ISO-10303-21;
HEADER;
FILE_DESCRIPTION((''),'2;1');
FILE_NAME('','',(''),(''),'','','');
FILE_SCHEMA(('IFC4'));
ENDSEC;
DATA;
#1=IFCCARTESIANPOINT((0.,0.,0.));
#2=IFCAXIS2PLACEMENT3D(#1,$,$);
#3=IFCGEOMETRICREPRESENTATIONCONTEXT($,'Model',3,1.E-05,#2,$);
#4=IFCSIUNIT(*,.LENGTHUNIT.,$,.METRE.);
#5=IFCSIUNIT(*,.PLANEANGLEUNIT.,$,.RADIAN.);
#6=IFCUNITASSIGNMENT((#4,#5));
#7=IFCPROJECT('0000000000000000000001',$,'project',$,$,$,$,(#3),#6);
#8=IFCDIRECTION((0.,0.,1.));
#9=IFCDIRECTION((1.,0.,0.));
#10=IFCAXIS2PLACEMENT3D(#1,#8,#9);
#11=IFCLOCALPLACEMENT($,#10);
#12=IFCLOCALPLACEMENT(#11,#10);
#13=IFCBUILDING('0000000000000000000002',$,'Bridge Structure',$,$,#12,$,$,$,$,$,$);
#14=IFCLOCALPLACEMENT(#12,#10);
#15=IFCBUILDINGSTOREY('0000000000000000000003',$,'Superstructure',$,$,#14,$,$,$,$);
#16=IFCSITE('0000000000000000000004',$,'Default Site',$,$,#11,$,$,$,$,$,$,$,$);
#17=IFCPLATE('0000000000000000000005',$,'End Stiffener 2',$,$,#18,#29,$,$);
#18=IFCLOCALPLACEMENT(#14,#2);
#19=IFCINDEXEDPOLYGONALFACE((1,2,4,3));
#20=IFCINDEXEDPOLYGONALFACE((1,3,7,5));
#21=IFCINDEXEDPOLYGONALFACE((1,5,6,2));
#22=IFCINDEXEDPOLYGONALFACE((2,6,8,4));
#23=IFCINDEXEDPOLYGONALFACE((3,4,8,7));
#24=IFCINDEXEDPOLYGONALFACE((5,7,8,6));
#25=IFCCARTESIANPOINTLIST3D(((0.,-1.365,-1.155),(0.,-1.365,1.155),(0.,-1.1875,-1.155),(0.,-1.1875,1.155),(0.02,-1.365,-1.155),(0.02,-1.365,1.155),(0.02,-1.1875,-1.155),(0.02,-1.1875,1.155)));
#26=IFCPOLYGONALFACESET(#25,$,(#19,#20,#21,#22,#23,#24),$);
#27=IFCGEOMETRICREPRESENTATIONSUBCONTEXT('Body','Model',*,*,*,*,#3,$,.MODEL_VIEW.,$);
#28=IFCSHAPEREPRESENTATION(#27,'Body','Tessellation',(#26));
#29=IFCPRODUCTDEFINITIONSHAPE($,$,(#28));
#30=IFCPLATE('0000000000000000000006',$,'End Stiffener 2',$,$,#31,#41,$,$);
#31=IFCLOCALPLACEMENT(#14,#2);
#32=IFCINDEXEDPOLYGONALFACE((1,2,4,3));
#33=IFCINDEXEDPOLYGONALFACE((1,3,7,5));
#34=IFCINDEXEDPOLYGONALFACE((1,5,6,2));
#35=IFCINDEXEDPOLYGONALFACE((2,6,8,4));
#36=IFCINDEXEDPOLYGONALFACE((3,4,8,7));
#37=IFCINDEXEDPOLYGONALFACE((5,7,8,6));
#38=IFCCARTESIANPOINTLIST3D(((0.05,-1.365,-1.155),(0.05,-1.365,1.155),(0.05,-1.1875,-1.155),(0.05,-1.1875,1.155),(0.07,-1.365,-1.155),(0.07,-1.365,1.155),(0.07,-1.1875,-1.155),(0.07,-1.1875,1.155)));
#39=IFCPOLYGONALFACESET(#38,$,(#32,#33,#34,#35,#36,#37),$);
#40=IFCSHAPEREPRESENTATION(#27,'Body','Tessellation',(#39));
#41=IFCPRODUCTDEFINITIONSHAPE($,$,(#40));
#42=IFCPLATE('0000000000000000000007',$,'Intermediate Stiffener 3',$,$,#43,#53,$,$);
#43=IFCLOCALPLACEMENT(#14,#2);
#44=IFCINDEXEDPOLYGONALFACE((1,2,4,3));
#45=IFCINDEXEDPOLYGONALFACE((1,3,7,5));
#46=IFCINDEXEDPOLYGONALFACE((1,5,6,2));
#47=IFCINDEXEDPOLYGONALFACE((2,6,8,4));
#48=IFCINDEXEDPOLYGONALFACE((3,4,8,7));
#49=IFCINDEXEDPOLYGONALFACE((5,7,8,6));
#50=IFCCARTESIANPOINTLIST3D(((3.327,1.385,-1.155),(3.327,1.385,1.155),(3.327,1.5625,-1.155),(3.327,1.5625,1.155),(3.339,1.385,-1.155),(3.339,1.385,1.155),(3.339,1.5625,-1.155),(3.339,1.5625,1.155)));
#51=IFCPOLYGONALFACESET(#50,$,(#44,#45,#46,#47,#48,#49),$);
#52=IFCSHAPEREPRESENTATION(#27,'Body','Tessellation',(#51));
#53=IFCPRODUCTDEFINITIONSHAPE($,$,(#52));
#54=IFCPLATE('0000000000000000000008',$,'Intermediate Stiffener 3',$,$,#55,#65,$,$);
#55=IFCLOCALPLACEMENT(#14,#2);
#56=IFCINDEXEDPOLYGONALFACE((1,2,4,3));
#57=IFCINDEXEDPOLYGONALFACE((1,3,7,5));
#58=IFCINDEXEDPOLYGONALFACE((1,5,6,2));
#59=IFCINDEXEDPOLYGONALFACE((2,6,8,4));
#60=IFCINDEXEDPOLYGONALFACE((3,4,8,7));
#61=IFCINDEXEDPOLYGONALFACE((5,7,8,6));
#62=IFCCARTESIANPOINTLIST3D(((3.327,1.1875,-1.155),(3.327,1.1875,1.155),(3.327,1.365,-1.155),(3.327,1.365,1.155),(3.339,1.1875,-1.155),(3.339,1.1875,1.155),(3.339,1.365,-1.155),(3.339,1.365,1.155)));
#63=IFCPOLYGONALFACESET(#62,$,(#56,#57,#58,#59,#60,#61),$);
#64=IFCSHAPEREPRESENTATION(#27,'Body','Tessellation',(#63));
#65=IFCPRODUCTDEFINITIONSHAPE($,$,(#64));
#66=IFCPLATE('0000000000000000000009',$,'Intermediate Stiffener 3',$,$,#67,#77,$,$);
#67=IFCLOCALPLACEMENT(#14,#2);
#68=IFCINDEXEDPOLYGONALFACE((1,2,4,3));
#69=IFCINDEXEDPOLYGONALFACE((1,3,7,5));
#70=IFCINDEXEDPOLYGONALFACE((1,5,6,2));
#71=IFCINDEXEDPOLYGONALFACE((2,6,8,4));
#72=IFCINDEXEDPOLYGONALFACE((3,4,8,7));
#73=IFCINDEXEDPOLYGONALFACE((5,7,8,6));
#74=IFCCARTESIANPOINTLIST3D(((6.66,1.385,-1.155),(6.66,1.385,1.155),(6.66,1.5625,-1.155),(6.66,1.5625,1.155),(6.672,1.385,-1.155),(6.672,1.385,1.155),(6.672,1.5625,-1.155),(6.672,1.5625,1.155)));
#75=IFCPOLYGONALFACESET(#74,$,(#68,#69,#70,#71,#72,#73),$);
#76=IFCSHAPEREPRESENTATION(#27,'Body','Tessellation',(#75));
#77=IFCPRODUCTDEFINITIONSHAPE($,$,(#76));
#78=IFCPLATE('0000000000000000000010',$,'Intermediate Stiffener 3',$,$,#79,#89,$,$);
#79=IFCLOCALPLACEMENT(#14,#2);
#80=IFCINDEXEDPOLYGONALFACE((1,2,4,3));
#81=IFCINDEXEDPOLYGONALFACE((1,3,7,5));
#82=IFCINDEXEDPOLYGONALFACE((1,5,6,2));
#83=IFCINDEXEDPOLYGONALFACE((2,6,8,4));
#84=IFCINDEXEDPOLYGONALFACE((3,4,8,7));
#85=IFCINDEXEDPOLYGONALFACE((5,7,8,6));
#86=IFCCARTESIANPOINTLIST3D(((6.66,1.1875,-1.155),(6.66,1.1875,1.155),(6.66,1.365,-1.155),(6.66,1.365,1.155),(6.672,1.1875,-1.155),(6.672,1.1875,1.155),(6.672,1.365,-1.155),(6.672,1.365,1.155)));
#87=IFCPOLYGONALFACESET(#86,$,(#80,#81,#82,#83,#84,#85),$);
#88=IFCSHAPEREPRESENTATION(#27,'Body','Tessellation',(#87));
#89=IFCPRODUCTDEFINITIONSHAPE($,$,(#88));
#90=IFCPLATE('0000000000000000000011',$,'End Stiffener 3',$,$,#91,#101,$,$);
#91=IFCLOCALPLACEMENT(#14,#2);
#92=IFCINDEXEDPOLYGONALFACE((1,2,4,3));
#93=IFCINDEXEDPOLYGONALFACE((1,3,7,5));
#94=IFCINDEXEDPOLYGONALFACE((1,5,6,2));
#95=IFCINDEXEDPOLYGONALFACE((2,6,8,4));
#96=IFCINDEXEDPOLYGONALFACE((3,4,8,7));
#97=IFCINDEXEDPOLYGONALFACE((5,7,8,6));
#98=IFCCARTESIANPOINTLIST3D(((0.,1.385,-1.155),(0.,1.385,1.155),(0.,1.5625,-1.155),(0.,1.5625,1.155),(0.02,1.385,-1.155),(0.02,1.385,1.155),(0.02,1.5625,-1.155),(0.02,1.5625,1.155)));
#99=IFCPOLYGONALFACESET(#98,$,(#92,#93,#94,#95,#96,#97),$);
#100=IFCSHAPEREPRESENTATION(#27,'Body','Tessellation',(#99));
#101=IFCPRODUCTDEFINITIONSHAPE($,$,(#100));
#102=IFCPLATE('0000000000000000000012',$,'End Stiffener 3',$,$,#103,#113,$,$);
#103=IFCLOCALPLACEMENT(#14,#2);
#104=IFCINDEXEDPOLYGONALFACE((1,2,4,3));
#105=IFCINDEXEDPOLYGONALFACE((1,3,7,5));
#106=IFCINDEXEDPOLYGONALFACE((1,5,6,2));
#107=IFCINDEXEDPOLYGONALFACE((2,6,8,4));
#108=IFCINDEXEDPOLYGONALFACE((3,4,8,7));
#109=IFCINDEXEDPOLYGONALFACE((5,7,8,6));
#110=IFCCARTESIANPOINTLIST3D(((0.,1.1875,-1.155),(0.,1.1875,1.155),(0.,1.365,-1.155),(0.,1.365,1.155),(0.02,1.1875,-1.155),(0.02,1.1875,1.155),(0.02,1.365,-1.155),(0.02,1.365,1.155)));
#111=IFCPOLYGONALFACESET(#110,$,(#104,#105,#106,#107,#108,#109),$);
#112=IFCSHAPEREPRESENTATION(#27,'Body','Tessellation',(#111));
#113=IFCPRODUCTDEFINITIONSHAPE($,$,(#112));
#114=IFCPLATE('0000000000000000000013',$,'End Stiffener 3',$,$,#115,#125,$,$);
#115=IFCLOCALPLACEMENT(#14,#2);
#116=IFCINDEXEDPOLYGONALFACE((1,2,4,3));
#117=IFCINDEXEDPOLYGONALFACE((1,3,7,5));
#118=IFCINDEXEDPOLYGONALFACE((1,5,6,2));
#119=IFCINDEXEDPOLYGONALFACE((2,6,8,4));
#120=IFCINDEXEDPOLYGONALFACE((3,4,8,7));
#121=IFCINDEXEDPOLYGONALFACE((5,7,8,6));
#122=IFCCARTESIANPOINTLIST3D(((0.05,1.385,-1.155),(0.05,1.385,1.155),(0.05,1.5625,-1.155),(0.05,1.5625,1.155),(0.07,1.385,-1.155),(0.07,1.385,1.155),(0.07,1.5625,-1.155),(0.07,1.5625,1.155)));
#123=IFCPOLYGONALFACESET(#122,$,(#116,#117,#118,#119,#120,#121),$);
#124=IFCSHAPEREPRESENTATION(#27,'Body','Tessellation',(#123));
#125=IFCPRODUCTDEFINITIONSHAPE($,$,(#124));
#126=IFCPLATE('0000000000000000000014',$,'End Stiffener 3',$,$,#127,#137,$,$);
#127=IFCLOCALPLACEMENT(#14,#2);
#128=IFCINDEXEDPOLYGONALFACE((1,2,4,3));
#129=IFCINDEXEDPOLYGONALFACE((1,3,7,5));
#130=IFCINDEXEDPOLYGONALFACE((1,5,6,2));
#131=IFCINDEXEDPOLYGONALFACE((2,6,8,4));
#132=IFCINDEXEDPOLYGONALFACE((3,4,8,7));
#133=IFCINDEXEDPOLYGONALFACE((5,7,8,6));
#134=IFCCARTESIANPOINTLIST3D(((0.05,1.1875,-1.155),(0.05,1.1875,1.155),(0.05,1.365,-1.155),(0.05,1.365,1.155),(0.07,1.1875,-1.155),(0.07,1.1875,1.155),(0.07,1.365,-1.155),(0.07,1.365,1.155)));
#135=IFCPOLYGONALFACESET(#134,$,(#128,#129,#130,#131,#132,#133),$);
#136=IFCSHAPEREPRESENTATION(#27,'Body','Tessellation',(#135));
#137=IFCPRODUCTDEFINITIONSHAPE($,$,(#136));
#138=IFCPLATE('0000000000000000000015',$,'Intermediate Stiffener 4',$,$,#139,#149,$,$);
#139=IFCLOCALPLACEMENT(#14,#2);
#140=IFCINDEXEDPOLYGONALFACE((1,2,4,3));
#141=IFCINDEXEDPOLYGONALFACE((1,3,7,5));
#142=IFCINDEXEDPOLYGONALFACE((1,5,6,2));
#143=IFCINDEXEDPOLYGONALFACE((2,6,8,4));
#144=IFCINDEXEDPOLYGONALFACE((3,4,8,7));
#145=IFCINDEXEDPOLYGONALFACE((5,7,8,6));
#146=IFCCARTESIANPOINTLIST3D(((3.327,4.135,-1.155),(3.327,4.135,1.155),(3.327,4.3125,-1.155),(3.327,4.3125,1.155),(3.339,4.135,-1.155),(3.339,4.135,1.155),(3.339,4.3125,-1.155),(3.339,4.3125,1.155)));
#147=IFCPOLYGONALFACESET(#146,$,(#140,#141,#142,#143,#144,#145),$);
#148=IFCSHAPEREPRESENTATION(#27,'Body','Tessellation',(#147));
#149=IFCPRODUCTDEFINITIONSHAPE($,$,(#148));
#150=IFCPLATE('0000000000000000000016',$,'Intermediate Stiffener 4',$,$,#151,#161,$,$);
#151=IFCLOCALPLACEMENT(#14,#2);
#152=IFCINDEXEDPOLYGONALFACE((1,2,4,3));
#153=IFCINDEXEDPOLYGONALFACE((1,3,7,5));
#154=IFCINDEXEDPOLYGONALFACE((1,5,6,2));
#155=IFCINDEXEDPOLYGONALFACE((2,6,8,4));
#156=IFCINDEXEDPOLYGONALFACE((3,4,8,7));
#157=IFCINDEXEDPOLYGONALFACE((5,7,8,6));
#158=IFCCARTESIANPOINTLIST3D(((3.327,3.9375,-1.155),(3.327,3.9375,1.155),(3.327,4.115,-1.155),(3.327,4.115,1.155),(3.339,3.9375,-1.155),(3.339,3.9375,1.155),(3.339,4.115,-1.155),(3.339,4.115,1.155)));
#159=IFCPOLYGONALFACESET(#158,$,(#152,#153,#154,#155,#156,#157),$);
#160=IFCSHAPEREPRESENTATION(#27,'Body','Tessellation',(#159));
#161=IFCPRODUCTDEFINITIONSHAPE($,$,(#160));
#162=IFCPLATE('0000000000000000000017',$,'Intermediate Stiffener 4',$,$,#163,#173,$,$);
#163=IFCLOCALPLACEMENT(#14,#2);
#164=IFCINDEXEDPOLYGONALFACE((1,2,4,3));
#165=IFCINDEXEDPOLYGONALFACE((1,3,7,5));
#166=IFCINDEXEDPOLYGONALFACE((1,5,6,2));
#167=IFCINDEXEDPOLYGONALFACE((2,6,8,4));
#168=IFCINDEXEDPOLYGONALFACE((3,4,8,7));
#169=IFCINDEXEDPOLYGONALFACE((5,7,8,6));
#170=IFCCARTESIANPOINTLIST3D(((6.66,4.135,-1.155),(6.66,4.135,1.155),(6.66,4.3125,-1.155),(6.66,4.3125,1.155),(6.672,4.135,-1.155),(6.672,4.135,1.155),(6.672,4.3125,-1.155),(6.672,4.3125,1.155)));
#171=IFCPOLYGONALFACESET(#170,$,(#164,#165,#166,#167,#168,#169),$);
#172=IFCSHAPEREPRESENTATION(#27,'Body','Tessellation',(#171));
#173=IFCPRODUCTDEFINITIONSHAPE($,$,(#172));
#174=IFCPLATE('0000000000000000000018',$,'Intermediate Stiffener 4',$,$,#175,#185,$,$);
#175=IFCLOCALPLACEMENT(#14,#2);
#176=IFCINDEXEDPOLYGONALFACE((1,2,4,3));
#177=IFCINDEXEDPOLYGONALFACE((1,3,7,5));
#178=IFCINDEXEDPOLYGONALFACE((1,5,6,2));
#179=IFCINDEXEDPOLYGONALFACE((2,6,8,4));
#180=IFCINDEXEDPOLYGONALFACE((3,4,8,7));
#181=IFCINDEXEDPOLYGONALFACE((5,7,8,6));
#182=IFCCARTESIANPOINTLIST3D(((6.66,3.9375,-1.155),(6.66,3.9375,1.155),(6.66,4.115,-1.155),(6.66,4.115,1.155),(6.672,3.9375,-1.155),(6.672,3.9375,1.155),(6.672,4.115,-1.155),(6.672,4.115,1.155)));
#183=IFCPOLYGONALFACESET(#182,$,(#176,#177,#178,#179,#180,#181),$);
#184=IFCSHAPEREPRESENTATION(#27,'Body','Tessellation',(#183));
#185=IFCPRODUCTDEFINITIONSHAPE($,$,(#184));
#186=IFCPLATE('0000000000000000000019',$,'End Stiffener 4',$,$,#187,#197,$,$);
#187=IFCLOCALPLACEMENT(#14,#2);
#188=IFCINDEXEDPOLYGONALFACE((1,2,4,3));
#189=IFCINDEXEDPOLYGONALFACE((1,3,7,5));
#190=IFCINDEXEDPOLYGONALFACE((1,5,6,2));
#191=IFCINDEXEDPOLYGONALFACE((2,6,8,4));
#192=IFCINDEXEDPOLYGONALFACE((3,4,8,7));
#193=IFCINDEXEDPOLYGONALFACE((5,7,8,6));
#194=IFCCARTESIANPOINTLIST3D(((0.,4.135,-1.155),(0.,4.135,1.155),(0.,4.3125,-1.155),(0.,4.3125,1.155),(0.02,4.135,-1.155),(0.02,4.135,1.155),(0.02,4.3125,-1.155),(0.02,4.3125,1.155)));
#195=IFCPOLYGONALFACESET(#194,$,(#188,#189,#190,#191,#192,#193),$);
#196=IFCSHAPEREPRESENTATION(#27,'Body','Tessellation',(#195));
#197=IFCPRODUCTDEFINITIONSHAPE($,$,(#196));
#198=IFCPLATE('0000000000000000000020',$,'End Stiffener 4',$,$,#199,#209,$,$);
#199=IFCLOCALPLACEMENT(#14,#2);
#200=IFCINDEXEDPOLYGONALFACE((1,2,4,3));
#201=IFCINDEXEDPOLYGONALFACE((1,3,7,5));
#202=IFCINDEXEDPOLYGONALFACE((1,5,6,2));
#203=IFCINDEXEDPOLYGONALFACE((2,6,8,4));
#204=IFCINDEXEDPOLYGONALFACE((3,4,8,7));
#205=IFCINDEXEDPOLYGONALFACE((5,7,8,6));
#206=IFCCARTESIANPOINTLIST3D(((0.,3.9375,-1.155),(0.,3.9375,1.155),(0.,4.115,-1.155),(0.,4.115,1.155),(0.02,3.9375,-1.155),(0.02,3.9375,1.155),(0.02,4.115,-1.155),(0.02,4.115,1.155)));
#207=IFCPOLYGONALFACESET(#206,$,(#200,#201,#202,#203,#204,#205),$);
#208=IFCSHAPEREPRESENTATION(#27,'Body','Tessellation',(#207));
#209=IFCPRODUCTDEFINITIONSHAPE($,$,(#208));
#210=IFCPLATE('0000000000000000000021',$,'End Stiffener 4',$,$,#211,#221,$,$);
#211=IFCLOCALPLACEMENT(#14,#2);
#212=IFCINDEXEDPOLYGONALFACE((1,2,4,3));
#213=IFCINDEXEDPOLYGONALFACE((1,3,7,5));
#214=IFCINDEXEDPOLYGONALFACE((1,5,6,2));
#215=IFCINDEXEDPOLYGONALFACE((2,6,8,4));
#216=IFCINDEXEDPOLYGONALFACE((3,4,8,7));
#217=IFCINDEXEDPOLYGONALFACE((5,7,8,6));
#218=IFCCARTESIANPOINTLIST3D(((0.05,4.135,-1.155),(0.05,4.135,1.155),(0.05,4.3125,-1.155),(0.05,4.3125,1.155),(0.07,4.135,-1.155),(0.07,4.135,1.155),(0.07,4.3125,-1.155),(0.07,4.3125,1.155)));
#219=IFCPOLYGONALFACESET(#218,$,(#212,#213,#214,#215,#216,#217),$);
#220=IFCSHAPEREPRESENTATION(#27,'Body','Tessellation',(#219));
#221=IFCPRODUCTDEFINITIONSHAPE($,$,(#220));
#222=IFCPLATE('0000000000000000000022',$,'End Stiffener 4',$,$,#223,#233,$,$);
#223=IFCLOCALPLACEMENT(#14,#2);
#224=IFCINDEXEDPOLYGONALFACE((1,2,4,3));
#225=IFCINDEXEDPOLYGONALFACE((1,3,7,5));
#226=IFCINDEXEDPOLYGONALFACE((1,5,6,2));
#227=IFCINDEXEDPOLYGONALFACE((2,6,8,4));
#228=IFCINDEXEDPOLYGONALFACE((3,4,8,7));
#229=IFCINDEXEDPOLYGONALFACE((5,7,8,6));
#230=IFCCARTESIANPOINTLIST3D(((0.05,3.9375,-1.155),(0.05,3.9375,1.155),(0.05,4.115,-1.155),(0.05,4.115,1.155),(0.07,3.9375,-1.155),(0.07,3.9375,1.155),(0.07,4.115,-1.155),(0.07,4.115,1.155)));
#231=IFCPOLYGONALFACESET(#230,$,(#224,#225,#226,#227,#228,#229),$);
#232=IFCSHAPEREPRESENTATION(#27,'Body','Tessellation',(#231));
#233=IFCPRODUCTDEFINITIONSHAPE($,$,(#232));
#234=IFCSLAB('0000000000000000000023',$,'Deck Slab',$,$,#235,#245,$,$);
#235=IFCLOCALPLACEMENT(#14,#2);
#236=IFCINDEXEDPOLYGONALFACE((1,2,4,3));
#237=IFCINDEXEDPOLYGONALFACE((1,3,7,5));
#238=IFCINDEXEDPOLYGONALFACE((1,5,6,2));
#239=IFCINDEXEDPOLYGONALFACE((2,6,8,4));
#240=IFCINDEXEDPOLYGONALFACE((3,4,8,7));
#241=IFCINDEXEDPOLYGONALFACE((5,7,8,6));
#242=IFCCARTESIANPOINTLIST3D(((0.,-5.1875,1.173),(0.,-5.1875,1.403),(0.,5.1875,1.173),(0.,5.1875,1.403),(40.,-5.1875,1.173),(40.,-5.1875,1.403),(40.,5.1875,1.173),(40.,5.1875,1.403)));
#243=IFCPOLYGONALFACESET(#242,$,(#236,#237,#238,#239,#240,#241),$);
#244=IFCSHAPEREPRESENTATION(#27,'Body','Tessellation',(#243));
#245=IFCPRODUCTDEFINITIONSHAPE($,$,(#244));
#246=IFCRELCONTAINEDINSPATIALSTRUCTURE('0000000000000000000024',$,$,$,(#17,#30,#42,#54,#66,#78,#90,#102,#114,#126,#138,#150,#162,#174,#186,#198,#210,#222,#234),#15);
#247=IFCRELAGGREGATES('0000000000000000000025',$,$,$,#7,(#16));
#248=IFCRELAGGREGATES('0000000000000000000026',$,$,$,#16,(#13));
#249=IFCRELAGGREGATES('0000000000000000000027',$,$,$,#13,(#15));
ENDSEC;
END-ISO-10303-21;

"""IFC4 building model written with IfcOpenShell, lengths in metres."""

from ifc_helpers import new_model, si_unit, frame, origin, origin_with_axes, origin_2d_with_axis, place, context, subcontext, project, spatial, polyline, rectangle, outline, extrude, element, save


model = new_model("IFC4")

# Units and contexts
model_context = context("Model", 3, precision=1e-05, world=origin())
body_context = subcontext(model_context, "Body", "Model", "MODEL_VIEW")
ifc_project = project(units=[si_unit("LENGTHUNIT", "METRE"), si_unit("PLANEANGLEUNIT", "RADIAN")], contexts=[model_context])

# Site, building, storey
site_placement = place(None, origin_with_axes())
site = spatial("IfcSite", under=ifc_project, at=site_placement, Name="Default Site")
building_placement = place(site_placement, origin_with_axes())
building = spatial("IfcBuilding", under=site, at=building_placement, Name="Bridge Structure")
storey_placement = place(building_placement, origin_with_axes())
storey = spatial("IfcBuildingStorey", under=building, at=storey_placement, Name="Superstructure")

# Plates
for number, where, z_axis, x_axis, name in (
    (1, (0.01, -1.2763, -1.155), (0.0, 0.0, 1.0), (1.0, 0.0, 0.0), "End Stiffener 2"),
    (2, (0.06, -1.2763, -1.155), (0.0, 0.0, 1.0), (1.0, 0.0, 0.0), "End Stiffener 2"),
):
    element("IfcPlate", number, at=place(storey_placement, frame(where, z_axis=z_axis, x_axis=x_axis)), inside=storey, Name=name, context=body_context, shape_type="SweptSolid", body=[
        extrude(rectangle(XDim=0.02, YDim=0.1775, at=origin_2d_with_axis()), origin_with_axes(), (0.0, 0.0, 1.0), 2.31),
    ])
for number, where, z_axis, x_axis, name in (
    (3, (3.333, 1.4738, -1.155), (0.0, 0.0, 1.0), (1.0, 0.0, 0.0), "Intermediate Stiffener 3"),
    (4, (3.333, 1.2763, -1.155), (0.0, 0.0, 1.0), (1.0, 0.0, 0.0), "Intermediate Stiffener 3"),
    (5, (6.666, 1.4738, -1.155), (0.0, 0.0, 1.0), (1.0, 0.0, 0.0), "Intermediate Stiffener 3"),
    (6, (6.666, 1.2763, -1.155), (0.0, 0.0, 1.0), (1.0, 0.0, 0.0), "Intermediate Stiffener 3"),
):
    element("IfcPlate", number, at=place(storey_placement, frame(where, z_axis=z_axis, x_axis=x_axis)), inside=storey, Name=name, context=body_context, shape_type="SweptSolid", body=[
        extrude(rectangle(XDim=0.012, YDim=0.1775, at=origin_2d_with_axis()), origin_with_axes(), (0.0, 0.0, 1.0), 2.31),
    ])
for number, where, z_axis, x_axis, name in (
    (7, (0.01, 1.4738, -1.155), (0.0, 0.0, 1.0), (1.0, 0.0, 0.0), "End Stiffener 3"),
    (8, (0.01, 1.2763, -1.155), (0.0, 0.0, 1.0), (1.0, 0.0, 0.0), "End Stiffener 3"),
    (9, (0.06, 1.4738, -1.155), (0.0, 0.0, 1.0), (1.0, 0.0, 0.0), "End Stiffener 3"),
    (10, (0.06, 1.2763, -1.155), (0.0, 0.0, 1.0), (1.0, 0.0, 0.0), "End Stiffener 3"),
):
    element("IfcPlate", number, at=place(storey_placement, frame(where, z_axis=z_axis, x_axis=x_axis)), inside=storey, Name=name, context=body_context, shape_type="SweptSolid", body=[
        extrude(rectangle(XDim=0.02, YDim=0.1775, at=origin_2d_with_axis()), origin_with_axes(), (0.0, 0.0, 1.0), 2.31),
    ])
for number, where, z_axis, x_axis, name in (
    (11, (3.333, 4.2237, -1.155), (0.0, 0.0, 1.0), (1.0, 0.0, 0.0), "Intermediate Stiffener 4"),
    (12, (3.333, 4.0263, -1.155), (0.0, 0.0, 1.0), (1.0, 0.0, 0.0), "Intermediate Stiffener 4"),
    (13, (6.666, 4.2237, -1.155), (0.0, 0.0, 1.0), (1.0, 0.0, 0.0), "Intermediate Stiffener 4"),
    (14, (6.666, 4.0263, -1.155), (0.0, 0.0, 1.0), (1.0, 0.0, 0.0), "Intermediate Stiffener 4"),
):
    element("IfcPlate", number, at=place(storey_placement, frame(where, z_axis=z_axis, x_axis=x_axis)), inside=storey, Name=name, context=body_context, shape_type="SweptSolid", body=[
        extrude(rectangle(XDim=0.012, YDim=0.1775, at=origin_2d_with_axis()), origin_with_axes(), (0.0, 0.0, 1.0), 2.31),
    ])
for number, where, z_axis, x_axis, name in (
    (15, (0.01, 4.2237, -1.155), (0.0, 0.0, 1.0), (1.0, 0.0, 0.0), "End Stiffener 4"),
    (16, (0.01, 4.0263, -1.155), (0.0, 0.0, 1.0), (1.0, 0.0, 0.0), "End Stiffener 4"),
    (17, (0.06, 4.2237, -1.155), (0.0, 0.0, 1.0), (1.0, 0.0, 0.0), "End Stiffener 4"),
    (18, (0.06, 4.0263, -1.155), (0.0, 0.0, 1.0), (1.0, 0.0, 0.0), "End Stiffener 4"),
):
    element("IfcPlate", number, at=place(storey_placement, frame(where, z_axis=z_axis, x_axis=x_axis)), inside=storey, Name=name, context=body_context, shape_type="SweptSolid", body=[
        extrude(rectangle(XDim=0.02, YDim=0.1775, at=origin_2d_with_axis()), origin_with_axes(), (0.0, 0.0, 1.0), 2.31),
    ])

# Slab
slab_placement = place(storey_placement, frame((0.0, 0.0, 1.173), z_axis=(0.0, 0.0, 1.0), x_axis=(1.0, 0.0, 0.0)))
element("IfcSlab", 19, at=slab_placement, inside=storey, Name="Deck Slab", context=body_context, shape_type="SweptSolid", body=[
    extrude(outline(polyline([(0.0, -5.1875), (40.0, -5.1875), (40.0, 5.1875), (0.0, 5.1875), (0.0, -5.1875)])), origin_with_axes(), (0.0, 0.0, 1.0), 0.23),
])

save(model, "model.ifc")
